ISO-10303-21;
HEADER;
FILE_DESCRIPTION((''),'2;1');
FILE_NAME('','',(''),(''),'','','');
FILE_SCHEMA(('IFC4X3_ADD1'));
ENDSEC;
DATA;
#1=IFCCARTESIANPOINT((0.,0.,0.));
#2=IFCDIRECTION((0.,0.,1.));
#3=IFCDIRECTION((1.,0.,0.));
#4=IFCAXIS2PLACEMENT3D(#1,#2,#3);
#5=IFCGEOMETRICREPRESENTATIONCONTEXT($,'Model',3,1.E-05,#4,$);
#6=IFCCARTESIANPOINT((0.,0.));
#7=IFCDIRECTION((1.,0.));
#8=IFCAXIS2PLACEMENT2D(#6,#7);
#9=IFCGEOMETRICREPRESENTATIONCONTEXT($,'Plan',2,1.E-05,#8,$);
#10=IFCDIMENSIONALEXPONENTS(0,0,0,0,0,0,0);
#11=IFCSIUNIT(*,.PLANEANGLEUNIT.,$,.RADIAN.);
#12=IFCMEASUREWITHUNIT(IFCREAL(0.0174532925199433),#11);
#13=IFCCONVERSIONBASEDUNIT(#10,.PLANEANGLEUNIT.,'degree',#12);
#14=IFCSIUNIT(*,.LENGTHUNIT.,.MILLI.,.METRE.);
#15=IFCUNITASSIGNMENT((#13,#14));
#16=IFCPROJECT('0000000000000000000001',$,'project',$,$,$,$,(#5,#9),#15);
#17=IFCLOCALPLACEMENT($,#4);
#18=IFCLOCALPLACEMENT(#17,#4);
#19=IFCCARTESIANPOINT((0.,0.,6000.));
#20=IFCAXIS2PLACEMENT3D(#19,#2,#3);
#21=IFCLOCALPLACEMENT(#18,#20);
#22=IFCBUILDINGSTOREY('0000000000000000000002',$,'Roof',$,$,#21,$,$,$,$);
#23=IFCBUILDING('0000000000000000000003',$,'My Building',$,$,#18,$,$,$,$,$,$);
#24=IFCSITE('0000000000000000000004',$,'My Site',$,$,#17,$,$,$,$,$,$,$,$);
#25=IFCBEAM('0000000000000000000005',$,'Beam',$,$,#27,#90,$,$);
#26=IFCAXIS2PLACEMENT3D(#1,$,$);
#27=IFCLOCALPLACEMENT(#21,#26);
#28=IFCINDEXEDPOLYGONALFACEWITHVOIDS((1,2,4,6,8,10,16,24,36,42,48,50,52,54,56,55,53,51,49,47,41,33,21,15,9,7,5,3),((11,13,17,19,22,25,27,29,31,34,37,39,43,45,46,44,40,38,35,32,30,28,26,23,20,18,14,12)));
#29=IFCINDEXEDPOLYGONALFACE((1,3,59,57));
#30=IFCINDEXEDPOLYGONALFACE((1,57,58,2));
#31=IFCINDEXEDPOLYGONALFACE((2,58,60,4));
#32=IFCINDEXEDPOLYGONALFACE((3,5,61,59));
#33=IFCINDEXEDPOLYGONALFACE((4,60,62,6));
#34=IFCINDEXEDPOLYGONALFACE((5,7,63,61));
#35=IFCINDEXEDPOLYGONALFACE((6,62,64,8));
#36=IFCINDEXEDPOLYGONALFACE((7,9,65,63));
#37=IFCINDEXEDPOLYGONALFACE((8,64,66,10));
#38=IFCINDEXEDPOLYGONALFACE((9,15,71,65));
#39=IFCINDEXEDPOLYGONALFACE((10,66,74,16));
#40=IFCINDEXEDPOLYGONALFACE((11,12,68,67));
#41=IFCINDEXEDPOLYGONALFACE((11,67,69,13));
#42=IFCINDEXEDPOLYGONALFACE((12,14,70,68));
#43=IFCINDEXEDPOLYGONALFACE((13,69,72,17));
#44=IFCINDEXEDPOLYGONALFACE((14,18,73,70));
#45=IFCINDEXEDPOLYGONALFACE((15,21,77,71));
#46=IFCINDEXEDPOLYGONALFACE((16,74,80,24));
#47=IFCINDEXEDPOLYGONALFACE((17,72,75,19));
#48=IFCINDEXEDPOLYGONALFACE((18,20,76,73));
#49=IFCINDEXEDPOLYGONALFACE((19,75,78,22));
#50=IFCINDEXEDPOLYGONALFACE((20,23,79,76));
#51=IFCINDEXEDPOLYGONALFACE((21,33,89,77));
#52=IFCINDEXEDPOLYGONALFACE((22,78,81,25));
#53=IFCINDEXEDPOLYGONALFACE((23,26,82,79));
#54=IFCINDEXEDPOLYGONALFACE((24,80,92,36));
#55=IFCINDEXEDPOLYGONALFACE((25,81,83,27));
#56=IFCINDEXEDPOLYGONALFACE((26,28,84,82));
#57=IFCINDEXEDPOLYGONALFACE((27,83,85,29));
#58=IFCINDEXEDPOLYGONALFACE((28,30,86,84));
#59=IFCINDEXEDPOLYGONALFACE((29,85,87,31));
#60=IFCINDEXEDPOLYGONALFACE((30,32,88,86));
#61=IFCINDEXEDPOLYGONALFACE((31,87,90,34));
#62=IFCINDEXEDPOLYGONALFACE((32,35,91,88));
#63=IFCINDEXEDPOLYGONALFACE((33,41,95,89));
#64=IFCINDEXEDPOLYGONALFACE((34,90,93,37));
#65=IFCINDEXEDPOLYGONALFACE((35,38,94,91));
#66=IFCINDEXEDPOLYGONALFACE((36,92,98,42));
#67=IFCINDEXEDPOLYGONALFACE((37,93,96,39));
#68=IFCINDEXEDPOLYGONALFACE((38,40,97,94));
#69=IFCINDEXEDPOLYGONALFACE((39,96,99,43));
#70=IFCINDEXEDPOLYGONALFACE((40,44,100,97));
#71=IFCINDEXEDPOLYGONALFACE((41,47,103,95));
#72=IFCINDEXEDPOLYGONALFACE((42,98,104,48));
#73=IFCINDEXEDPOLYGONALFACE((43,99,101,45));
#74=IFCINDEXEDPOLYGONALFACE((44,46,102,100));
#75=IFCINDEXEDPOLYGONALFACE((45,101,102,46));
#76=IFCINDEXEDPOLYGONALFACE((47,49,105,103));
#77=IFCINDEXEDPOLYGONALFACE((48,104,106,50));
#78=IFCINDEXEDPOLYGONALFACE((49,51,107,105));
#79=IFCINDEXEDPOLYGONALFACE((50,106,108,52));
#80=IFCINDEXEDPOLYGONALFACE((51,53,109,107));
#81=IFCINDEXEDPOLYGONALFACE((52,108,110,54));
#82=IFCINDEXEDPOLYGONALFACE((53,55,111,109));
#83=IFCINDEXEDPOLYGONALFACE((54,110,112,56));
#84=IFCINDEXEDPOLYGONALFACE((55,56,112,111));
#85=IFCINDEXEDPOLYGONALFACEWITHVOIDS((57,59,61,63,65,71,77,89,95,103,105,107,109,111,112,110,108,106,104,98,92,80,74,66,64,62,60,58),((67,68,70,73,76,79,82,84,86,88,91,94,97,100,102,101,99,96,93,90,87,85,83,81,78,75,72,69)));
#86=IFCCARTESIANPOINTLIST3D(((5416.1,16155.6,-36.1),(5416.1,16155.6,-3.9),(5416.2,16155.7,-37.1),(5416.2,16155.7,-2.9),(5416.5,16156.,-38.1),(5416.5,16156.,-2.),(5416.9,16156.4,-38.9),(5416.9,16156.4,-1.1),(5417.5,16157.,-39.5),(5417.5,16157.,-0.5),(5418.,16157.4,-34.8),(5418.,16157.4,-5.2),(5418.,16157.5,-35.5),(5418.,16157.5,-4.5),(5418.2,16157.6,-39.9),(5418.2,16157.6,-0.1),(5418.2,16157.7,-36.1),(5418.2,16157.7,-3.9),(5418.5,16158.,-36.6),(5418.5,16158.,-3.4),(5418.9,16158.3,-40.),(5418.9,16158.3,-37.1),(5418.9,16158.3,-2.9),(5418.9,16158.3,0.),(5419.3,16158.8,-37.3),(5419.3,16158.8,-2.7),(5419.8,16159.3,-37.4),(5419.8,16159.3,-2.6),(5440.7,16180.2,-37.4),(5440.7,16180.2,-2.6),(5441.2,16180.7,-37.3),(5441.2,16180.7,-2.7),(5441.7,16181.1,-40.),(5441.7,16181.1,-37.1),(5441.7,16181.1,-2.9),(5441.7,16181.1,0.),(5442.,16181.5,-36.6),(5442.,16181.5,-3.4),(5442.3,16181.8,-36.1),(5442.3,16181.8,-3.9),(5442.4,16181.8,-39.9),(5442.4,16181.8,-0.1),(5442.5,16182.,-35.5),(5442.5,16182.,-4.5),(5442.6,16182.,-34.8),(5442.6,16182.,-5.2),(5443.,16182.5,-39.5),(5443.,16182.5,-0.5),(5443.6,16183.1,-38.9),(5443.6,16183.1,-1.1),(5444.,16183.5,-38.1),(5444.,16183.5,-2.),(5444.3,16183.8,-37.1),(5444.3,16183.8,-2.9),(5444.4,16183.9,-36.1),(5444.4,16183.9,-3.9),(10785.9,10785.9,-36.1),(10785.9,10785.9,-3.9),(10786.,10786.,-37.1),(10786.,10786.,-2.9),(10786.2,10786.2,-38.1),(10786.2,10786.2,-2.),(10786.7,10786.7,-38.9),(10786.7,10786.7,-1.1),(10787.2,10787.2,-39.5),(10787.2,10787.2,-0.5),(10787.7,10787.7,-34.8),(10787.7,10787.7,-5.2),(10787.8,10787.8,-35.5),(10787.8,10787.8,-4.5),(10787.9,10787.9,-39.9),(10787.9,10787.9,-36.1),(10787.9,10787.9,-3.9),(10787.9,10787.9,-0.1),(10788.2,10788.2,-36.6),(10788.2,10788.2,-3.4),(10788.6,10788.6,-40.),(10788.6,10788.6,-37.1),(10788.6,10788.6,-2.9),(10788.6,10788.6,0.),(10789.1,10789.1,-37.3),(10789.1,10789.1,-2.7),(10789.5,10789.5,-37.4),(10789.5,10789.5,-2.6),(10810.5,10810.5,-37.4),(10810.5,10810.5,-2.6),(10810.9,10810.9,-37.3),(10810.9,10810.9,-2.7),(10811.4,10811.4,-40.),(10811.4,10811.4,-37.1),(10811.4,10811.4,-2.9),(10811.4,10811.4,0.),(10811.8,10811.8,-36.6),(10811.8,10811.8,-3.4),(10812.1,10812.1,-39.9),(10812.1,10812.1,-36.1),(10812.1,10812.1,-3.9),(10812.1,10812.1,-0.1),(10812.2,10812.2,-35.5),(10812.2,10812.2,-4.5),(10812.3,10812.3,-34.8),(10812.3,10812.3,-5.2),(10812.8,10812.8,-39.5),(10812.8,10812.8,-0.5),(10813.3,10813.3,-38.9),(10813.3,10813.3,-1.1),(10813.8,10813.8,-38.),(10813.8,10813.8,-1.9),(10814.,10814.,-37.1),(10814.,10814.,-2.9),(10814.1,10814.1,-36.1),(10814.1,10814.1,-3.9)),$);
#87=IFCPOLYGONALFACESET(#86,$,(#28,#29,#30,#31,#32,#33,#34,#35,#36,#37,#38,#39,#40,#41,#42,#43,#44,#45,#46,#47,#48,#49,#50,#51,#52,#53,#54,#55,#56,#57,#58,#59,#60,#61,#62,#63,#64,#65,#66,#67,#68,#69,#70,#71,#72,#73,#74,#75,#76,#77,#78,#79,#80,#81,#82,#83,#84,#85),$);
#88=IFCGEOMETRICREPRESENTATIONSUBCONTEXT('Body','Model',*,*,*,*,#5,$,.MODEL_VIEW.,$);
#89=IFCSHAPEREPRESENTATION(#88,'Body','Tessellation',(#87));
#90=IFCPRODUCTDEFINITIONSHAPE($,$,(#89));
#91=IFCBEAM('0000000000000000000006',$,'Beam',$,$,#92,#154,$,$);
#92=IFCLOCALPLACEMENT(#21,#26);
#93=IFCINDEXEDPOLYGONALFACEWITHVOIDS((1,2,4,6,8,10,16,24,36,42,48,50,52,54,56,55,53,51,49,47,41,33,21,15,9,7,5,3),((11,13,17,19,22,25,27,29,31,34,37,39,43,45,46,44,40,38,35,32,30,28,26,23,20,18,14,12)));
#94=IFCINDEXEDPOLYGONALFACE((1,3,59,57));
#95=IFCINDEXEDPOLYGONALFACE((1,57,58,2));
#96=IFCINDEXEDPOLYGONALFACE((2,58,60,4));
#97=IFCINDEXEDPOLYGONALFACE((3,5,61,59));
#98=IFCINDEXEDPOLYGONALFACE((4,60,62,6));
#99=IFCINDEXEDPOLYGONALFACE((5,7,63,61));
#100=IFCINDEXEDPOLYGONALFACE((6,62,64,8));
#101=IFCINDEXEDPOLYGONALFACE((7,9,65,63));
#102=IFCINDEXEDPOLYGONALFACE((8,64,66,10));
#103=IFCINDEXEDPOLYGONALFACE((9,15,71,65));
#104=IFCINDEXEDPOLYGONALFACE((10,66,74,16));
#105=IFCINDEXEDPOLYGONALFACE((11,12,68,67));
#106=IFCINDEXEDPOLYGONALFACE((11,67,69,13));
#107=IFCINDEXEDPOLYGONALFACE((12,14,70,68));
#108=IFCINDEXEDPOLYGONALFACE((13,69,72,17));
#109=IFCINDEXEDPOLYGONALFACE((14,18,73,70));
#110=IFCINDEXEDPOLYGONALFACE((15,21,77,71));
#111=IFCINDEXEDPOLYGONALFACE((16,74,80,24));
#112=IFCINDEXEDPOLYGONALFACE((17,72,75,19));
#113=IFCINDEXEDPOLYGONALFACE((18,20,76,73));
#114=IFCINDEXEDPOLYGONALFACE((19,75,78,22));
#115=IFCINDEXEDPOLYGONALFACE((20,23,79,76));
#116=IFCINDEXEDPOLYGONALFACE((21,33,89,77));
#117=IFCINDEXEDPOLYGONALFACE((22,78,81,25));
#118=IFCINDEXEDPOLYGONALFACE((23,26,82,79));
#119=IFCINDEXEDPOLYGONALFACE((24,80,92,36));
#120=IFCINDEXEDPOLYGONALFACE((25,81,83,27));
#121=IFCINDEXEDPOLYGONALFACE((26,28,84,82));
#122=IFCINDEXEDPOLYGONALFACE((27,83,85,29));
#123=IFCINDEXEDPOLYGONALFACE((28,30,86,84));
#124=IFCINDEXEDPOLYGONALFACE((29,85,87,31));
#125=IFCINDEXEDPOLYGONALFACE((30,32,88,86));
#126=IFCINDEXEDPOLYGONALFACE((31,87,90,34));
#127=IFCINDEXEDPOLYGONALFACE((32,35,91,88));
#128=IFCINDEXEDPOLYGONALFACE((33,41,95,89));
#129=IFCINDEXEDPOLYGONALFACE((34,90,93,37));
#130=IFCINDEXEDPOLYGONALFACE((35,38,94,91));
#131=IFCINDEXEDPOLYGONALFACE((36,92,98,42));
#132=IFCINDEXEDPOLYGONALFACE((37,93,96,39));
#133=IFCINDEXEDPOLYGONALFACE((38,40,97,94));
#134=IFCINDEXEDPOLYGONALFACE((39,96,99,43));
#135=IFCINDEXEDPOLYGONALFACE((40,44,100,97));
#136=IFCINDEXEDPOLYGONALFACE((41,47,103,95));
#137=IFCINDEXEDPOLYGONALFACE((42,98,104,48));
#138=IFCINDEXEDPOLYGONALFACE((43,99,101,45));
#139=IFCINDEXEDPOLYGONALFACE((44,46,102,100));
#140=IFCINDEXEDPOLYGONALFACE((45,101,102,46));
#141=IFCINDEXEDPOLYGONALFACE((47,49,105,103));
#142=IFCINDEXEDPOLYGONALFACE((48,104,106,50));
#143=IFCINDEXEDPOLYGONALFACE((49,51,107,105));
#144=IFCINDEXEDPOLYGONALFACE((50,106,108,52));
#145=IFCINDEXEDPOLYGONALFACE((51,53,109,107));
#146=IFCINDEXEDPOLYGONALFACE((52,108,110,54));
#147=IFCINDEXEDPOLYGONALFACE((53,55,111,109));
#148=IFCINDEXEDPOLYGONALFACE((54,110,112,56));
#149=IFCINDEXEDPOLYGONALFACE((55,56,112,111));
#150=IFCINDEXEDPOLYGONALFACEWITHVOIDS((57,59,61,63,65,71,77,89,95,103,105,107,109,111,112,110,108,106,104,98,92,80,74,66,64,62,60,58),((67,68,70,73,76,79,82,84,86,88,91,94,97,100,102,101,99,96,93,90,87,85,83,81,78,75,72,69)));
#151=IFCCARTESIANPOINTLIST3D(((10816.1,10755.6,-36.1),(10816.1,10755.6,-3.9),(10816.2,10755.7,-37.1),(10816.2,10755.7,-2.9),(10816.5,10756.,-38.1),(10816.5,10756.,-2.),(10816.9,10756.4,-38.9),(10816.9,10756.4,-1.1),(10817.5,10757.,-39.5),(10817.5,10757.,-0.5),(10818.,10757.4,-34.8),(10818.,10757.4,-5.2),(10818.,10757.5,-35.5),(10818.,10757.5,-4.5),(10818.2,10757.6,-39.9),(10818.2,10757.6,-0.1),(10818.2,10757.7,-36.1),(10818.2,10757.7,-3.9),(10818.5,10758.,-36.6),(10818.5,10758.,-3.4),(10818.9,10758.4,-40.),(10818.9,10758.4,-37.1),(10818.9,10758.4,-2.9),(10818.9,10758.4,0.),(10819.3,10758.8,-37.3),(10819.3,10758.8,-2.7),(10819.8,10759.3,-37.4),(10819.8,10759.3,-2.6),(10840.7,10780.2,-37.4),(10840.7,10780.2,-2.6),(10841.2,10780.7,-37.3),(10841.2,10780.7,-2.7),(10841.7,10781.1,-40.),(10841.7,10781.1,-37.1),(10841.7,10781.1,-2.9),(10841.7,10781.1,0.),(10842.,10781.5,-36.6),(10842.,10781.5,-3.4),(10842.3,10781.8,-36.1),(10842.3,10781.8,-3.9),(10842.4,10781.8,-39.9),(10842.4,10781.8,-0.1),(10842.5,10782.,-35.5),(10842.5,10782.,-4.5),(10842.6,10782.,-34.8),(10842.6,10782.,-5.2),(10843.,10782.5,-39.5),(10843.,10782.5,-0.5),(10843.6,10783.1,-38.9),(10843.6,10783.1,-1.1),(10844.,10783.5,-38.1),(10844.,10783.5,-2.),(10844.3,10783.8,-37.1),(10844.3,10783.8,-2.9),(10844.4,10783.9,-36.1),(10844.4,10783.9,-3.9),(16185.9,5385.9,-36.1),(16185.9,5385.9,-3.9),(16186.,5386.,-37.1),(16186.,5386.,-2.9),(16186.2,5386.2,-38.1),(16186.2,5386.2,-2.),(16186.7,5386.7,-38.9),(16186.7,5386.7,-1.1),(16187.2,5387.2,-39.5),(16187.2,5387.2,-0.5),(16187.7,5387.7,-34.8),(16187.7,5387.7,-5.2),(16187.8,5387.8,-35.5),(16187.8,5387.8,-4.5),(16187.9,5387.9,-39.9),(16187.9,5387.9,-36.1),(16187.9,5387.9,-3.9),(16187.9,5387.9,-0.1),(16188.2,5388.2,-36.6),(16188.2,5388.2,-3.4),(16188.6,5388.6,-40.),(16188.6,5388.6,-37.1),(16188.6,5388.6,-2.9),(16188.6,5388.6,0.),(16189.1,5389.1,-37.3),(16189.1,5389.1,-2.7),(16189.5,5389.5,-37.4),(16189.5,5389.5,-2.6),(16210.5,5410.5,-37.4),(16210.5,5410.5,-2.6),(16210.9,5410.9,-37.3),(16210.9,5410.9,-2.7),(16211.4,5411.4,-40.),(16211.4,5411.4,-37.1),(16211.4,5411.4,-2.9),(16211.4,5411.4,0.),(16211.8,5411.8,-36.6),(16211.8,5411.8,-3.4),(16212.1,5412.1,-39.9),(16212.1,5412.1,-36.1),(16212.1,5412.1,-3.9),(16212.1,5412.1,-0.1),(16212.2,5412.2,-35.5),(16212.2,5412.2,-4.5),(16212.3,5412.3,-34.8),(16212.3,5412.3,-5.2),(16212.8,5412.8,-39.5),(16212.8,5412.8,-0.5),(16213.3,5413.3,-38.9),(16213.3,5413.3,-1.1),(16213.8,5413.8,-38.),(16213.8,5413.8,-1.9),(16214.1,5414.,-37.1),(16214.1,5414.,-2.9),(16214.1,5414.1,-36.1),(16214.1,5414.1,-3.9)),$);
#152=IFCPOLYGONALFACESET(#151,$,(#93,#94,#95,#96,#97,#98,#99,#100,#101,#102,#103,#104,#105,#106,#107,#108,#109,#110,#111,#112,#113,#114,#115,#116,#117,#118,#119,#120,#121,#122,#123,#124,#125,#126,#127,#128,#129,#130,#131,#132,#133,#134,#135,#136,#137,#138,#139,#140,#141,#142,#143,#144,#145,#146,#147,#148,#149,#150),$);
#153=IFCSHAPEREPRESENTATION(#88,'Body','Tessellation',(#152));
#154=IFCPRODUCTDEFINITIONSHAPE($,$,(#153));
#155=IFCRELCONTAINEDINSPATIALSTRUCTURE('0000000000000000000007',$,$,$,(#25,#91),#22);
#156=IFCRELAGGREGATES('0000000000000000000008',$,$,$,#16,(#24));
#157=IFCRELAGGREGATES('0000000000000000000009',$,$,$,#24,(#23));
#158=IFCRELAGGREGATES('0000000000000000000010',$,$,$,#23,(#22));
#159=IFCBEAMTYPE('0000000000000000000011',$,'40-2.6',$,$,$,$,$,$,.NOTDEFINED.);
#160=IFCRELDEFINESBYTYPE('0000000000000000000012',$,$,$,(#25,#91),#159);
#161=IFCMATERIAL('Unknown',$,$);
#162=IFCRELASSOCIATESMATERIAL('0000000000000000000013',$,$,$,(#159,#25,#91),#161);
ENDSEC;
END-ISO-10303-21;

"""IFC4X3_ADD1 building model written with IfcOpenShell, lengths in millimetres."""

from ifc_helpers import new_model, entity, si_unit, converted_unit, frame, origin_with_axes, origin_2d_with_axis, place, context, subcontext, project, spatial, hollow_rectangle, extrude, material, material_profile, profile_set, profile_usage, type_object, element, save


model = new_model("IFC4X3_ADD1")

# Units and contexts
model_context = context("Model", 3, precision=1e-05, world=origin_with_axes())
plan_context = context("Plan", 2, precision=1e-05, world=origin_2d_with_axis())
body_context = subcontext(model_context, "Body", "Model", "MODEL_VIEW")
ifc_project = project(units=[converted_unit("PLANEANGLEUNIT", "degree", entity("IfcReal", 0.0174532925199433), si_unit("PLANEANGLEUNIT", "RADIAN"), dimensions=[0, 0, 0, 0, 0, 0, 0]), si_unit("LENGTHUNIT", "METRE", prefix="MILLI")], contexts=[model_context, plan_context])

# Site, building, storey
site_placement = place(None, origin_with_axes())
site = spatial("IfcSite", under=ifc_project, at=site_placement, Name="My Site")
building_placement = place(site_placement, origin_with_axes())
building = spatial("IfcBuilding", under=site, at=building_placement, Name="My Building")
storey_placement = place(building_placement, frame((0.0, 0.0, 6000.0), z_axis=(0.0, 0.0, 1.0), x_axis=(1.0, 0.0, 0.0)))
storey = spatial("IfcBuildingStorey", under=building, at=storey_placement, Name="Roof")

# Beams
ifc_material = material(Name="Unknown")
ifc_material_profile_1 = material_profile(ifc_material, hollow_rectangle(XDim=40.0, YDim=40.0, WallThickness=2.6, InnerFilletRadius=2.6, OuterFilletRadius=3.9))
ifc_profile_set_1 = profile_set([ifc_material_profile_1])
ifc_profile_usage_1 = profile_usage(ifc_profile_set_1, cardinal=8)
beam_type_1 = type_object("IfcBeamType", Name="40-2.6", PredefinedType="NOTDEFINED", material=ifc_profile_set_1)
beam_1_placement = place(storey_placement, frame((10800.0, 10800.0, 0.0), z_axis=(-0.707107, 0.707107, 0.0), x_axis=(-0.707107, -0.707107, 0.0)))
element("IfcBeam", 1, at=beam_1_placement, inside=storey, type_object=beam_type_1, material=ifc_profile_usage_1, Name="Beam", context=body_context, shape_type="SweptSolid", body=[
    extrude(hollow_rectangle(XDim=40.0, YDim=40.0, WallThickness=2.6, InnerFilletRadius=2.6, OuterFilletRadius=3.9), frame((0.0, -20.0, 0.0), z_axis=(0.0, 0.0, 1.0), x_axis=(1.0, 0.0, 0.0)), (0.0, 0.0, 1.0), 7594.0),
])
ifc_profile_usage_2 = profile_usage(ifc_profile_set_1, cardinal=8)
beam_2_placement = place(storey_placement, frame((16200.0, 5400.0, 0.0), z_axis=(-0.707107, 0.707107, 0.0), x_axis=(-0.707107, -0.707107, 0.0)))
element("IfcBeam", 2, at=beam_2_placement, inside=storey, type_object=beam_type_1, material=ifc_profile_usage_2, Name="Beam", context=body_context, shape_type="SweptSolid", body=[
    extrude(hollow_rectangle(XDim=40.0, YDim=40.0, WallThickness=2.6, InnerFilletRadius=2.6, OuterFilletRadius=3.9), frame((0.0, -20.0, 0.0), z_axis=(0.0, 0.0, 1.0), x_axis=(1.0, 0.0, 0.0)), (0.0, 0.0, 1.0), 7594.0),
])

save(model, "model.ifc")
